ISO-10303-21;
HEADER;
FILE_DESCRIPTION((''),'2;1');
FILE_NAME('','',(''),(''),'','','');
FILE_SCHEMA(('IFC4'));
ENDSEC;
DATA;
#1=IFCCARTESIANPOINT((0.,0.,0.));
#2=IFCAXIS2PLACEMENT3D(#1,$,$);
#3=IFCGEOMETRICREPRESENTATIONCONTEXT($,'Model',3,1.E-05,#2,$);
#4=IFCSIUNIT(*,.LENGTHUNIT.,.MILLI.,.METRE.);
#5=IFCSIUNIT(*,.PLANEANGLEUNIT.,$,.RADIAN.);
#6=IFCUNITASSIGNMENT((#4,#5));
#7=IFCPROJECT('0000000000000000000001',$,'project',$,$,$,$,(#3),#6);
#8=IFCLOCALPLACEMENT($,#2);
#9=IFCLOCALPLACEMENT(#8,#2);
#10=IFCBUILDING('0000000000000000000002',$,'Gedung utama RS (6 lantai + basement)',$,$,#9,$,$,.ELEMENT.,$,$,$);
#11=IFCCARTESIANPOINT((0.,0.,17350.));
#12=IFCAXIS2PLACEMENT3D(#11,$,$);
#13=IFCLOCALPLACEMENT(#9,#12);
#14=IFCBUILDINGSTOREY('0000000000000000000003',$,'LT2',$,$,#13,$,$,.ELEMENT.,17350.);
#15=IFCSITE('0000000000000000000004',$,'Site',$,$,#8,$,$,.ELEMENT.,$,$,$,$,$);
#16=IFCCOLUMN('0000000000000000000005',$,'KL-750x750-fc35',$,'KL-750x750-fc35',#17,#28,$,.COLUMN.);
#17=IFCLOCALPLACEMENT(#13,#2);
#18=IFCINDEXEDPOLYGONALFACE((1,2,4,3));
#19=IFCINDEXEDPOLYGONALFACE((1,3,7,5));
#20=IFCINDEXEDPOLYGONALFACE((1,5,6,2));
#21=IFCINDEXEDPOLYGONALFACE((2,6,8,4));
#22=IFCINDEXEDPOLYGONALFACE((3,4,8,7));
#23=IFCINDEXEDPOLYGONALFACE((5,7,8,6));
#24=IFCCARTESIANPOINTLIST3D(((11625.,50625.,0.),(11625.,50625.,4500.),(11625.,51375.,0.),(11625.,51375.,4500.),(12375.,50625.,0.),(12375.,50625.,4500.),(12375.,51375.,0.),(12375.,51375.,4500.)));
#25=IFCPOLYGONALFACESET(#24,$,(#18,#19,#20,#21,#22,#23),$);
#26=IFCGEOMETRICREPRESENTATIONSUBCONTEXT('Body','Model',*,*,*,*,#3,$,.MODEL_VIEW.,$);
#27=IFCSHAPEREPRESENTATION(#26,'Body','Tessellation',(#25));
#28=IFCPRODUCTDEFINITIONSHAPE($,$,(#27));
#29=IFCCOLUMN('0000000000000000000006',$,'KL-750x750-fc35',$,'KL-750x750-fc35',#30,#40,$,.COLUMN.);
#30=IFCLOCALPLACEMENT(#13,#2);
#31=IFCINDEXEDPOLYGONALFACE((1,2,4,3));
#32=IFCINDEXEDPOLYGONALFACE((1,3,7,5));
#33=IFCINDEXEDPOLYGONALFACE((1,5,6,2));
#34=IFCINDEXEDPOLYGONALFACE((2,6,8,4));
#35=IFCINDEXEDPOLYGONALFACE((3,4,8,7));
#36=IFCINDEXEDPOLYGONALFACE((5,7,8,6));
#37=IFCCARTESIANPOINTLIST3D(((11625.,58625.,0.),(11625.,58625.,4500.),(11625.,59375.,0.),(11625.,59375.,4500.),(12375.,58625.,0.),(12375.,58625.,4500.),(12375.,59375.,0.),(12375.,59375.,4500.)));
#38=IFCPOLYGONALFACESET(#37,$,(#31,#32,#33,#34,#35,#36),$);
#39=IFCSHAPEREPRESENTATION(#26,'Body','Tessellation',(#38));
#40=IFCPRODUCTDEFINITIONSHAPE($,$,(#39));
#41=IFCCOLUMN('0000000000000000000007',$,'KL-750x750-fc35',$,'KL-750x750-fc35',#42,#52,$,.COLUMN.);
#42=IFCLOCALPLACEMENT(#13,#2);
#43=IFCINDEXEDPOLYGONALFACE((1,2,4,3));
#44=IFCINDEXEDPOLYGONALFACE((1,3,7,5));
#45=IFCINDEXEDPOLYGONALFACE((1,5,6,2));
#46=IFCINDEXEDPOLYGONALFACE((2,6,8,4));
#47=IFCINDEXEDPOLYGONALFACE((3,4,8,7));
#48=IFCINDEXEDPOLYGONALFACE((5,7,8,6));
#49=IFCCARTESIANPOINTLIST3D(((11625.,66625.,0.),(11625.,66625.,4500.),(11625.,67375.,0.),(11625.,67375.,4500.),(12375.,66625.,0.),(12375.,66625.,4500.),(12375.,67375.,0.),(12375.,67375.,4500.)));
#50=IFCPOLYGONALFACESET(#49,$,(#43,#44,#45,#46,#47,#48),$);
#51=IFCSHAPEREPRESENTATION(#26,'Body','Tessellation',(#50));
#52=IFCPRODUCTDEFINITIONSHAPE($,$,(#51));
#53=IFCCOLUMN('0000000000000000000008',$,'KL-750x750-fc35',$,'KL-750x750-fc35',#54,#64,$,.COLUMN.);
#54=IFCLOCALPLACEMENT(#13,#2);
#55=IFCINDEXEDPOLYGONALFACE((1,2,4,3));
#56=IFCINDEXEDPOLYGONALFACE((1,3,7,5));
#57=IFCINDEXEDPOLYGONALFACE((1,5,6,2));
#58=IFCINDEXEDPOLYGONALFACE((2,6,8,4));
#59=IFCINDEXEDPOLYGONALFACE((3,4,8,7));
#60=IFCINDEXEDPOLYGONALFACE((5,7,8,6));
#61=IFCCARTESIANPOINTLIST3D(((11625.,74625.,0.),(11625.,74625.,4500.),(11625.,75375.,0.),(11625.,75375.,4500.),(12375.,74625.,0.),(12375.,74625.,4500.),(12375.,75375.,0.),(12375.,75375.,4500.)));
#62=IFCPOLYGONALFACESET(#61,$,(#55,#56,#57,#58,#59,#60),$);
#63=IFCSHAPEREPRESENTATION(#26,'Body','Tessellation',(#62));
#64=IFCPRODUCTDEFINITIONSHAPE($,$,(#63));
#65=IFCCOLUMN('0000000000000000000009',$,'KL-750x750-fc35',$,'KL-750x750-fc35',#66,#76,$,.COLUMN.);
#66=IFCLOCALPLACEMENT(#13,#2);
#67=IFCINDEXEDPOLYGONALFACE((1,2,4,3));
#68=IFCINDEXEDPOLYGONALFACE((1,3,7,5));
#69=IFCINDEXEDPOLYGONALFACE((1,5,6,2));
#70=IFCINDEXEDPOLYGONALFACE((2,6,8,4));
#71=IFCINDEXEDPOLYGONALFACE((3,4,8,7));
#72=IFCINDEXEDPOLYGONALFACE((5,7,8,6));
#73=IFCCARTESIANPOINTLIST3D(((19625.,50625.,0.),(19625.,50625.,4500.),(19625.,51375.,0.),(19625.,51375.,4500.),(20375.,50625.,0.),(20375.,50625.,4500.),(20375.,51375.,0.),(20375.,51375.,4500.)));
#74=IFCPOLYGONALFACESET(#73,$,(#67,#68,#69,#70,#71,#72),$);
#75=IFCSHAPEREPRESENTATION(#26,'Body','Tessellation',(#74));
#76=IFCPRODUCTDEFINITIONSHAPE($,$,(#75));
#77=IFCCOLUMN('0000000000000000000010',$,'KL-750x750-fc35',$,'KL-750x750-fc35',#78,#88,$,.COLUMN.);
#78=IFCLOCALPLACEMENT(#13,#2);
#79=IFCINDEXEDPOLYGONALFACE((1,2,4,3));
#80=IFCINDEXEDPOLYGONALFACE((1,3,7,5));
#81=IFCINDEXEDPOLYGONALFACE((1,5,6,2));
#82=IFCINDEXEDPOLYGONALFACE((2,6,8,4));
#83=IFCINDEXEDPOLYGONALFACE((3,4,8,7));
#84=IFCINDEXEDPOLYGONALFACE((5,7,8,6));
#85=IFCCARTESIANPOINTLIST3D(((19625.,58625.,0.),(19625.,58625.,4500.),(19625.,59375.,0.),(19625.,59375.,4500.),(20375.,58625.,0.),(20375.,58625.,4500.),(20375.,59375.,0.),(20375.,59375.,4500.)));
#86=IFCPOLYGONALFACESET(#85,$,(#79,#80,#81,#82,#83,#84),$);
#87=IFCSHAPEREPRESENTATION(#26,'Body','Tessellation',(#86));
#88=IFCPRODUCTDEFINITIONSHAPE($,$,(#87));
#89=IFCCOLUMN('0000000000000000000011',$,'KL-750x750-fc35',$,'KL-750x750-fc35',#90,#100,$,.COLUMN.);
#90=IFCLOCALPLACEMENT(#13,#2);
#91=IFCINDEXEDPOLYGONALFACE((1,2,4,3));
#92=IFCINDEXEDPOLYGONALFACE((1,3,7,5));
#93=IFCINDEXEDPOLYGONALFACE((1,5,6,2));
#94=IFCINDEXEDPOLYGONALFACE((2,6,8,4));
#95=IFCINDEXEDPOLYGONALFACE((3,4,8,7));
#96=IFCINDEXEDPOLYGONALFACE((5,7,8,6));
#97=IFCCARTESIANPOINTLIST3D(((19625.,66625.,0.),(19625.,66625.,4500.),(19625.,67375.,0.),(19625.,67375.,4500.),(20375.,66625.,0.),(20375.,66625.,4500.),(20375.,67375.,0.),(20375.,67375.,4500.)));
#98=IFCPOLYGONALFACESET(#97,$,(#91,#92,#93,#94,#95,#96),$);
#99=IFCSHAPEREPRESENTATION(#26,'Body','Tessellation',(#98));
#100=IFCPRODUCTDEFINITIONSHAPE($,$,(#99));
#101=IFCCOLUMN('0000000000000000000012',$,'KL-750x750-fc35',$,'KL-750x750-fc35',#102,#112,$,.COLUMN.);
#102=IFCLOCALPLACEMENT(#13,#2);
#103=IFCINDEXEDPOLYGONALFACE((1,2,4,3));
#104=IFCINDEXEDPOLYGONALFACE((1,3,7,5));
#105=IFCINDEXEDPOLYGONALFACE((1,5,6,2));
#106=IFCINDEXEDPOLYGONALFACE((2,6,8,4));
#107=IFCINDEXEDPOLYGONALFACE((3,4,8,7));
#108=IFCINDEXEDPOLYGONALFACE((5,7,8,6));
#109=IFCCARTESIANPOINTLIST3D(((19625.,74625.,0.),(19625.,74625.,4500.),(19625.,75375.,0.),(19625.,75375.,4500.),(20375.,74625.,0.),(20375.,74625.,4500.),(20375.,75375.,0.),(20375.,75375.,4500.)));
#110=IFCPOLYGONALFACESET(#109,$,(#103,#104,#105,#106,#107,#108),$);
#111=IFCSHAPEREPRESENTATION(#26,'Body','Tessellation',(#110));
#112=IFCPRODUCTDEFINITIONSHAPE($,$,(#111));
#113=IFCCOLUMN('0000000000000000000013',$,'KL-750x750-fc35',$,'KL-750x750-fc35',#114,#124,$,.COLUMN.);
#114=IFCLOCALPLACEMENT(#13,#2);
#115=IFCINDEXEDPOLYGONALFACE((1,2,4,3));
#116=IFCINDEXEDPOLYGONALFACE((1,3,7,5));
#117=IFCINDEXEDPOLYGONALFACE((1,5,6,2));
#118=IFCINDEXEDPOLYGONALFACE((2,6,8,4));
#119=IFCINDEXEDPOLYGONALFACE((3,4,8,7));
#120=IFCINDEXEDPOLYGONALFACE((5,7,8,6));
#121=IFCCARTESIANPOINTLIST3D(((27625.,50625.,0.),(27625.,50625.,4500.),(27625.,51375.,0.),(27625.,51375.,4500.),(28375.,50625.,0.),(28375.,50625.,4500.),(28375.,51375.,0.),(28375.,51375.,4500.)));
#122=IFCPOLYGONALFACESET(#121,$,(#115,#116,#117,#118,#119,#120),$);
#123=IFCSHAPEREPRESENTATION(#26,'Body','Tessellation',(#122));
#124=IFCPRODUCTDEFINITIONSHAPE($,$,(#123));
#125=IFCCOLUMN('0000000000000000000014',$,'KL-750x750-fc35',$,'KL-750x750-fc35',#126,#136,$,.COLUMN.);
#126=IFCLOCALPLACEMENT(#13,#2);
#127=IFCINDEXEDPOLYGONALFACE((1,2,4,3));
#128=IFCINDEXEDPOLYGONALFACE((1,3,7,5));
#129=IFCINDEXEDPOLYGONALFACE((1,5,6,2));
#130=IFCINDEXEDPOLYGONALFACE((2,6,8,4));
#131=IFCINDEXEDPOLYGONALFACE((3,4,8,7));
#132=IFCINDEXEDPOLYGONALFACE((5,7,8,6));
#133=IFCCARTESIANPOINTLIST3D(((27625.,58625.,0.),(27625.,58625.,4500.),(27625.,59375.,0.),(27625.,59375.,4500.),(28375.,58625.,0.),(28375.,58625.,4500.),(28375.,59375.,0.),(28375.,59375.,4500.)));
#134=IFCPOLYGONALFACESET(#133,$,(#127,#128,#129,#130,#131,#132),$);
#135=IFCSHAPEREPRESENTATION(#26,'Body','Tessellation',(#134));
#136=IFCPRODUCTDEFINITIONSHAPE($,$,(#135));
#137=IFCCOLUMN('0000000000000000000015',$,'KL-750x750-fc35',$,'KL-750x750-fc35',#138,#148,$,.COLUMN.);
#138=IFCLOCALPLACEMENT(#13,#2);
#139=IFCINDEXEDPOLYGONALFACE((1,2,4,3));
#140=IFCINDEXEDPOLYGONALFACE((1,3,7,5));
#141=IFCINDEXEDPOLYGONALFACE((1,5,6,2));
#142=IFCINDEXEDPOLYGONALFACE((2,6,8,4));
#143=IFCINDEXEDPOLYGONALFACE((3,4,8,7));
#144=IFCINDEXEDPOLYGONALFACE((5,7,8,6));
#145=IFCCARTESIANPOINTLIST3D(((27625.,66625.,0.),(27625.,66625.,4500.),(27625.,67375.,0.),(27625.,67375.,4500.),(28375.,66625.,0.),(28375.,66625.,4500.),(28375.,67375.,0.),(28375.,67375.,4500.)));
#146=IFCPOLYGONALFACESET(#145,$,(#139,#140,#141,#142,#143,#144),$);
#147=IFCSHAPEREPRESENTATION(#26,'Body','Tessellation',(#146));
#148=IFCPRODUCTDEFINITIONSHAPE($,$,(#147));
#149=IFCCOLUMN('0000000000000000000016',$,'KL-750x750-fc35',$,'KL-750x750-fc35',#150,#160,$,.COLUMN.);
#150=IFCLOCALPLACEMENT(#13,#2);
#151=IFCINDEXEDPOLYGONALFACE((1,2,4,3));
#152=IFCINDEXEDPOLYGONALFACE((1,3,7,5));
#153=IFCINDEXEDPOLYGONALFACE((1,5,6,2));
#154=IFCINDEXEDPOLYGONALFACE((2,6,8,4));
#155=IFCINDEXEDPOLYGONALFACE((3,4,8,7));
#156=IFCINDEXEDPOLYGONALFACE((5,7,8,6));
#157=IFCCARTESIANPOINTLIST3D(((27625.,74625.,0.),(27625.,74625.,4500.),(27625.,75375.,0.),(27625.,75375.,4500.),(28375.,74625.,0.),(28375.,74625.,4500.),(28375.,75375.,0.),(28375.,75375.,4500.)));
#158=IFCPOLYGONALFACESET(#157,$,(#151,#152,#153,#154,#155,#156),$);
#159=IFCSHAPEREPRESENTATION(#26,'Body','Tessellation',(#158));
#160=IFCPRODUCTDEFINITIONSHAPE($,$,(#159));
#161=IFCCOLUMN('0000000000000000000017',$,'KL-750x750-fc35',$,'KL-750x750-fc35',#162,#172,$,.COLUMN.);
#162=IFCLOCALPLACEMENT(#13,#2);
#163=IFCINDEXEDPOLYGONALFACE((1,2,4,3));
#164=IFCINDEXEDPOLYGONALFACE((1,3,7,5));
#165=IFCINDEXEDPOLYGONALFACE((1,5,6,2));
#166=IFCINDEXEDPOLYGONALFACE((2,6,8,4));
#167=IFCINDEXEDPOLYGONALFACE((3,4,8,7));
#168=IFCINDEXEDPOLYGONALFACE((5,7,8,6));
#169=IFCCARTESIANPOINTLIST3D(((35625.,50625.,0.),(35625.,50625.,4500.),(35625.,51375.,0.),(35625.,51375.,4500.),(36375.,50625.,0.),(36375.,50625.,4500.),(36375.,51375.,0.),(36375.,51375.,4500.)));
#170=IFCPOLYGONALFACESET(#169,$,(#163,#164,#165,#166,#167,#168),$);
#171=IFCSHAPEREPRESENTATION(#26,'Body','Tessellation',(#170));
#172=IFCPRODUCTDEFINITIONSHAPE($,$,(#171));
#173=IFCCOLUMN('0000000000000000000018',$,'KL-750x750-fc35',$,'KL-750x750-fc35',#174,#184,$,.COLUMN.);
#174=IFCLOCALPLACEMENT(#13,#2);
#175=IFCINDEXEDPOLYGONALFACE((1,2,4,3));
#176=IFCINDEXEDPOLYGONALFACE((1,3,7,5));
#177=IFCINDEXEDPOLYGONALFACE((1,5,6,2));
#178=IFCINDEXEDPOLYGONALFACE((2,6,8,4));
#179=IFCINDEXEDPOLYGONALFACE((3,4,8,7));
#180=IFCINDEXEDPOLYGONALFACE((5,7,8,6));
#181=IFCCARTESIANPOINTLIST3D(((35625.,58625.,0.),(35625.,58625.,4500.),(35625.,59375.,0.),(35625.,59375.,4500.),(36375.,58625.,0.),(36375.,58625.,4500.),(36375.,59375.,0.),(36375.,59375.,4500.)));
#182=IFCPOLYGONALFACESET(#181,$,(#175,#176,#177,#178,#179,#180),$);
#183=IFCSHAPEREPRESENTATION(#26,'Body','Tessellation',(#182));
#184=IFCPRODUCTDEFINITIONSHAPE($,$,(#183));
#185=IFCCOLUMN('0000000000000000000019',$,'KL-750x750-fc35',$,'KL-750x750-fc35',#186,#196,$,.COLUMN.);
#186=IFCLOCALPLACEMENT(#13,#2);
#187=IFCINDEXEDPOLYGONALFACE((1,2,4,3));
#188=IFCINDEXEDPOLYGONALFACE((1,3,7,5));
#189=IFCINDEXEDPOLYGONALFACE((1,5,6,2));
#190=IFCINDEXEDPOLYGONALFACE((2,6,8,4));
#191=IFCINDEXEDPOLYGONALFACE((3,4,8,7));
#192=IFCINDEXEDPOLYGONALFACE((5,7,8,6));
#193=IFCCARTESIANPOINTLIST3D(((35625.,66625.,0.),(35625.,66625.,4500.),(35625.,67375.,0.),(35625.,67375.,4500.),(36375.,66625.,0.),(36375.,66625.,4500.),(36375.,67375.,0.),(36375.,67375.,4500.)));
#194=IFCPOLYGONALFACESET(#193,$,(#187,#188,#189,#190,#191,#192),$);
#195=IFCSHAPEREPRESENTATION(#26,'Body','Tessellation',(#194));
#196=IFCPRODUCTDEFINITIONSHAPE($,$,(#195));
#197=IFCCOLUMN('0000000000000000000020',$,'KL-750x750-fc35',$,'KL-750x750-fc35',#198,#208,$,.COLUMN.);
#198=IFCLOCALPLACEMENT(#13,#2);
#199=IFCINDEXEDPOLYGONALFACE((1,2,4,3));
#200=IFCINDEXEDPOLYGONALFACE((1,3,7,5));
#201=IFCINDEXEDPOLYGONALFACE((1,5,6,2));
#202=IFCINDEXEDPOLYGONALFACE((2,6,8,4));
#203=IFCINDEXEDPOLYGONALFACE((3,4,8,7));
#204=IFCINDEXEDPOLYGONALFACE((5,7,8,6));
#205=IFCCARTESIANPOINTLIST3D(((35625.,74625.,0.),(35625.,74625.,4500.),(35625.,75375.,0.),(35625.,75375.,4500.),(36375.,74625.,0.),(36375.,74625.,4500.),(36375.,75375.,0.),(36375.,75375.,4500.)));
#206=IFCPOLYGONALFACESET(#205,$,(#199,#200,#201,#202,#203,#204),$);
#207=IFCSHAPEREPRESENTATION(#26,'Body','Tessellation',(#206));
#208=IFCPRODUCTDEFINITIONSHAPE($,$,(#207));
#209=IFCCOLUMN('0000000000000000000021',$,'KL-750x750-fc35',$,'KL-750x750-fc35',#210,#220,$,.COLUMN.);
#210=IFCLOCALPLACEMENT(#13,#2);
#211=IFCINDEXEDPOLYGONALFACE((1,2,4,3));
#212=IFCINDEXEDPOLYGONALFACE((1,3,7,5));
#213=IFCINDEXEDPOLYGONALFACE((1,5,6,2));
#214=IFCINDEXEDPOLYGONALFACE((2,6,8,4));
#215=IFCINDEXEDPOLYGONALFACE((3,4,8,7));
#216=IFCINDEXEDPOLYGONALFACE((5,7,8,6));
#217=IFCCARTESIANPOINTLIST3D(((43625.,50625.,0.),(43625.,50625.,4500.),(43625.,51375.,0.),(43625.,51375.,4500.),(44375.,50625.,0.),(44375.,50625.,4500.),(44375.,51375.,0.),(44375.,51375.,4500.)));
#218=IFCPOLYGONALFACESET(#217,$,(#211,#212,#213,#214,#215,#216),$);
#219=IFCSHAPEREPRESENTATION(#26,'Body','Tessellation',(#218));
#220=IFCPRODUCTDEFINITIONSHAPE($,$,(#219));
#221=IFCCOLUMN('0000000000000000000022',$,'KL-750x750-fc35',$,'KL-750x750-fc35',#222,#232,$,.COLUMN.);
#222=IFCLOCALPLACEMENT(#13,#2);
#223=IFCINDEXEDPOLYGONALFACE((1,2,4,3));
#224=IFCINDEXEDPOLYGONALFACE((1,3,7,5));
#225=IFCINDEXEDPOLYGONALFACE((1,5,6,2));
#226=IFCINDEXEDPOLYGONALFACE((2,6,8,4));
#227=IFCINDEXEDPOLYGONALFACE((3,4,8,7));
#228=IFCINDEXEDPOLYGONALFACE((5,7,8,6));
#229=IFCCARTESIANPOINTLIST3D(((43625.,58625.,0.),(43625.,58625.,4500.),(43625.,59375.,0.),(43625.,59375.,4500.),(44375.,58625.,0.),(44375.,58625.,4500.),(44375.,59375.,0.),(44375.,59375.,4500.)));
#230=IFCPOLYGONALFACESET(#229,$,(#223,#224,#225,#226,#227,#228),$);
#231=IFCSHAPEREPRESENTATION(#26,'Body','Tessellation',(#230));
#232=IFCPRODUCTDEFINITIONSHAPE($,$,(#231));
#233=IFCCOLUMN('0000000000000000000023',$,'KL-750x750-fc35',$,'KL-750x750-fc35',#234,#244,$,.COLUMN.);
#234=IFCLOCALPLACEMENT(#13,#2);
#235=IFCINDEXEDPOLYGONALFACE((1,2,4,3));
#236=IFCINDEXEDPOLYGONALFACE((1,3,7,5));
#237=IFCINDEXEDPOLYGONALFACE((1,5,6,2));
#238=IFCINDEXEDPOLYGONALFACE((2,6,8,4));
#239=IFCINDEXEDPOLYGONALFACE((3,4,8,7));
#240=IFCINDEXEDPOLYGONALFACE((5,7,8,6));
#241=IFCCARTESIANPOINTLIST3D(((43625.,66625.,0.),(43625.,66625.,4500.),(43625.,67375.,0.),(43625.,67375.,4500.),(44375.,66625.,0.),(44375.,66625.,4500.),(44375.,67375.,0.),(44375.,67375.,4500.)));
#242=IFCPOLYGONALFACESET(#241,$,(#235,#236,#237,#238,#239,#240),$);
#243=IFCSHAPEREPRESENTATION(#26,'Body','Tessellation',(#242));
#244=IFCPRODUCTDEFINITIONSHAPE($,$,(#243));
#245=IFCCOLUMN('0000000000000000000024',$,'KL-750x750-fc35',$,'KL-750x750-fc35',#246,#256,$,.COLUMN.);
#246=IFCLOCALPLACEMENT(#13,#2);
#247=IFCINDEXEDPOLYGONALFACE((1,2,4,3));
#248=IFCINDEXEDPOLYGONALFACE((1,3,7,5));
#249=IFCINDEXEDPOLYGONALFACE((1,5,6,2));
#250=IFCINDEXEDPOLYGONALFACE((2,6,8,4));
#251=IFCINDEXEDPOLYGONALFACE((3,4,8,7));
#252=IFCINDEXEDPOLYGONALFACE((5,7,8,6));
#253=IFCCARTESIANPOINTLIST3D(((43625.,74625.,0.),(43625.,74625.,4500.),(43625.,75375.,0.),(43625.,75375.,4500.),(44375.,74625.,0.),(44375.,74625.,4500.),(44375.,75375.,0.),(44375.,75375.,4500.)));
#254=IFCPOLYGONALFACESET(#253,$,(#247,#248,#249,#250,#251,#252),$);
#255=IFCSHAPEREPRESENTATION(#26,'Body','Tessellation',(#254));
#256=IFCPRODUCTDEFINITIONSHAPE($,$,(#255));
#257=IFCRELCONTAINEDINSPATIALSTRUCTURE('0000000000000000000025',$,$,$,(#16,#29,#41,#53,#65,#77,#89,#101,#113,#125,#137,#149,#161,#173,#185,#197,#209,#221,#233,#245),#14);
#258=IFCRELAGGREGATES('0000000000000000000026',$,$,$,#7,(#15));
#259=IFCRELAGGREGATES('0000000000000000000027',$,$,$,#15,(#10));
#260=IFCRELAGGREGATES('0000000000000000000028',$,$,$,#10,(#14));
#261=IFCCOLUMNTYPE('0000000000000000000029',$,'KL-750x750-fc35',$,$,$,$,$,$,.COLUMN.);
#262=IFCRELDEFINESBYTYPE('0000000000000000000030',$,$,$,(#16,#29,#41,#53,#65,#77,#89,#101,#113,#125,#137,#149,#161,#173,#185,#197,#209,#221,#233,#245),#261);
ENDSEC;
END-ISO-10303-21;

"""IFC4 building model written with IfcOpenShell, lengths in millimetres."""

from ifc_helpers import new_model, si_unit, frame, origin, origin_2d, place, context, subcontext, project, spatial, rectangle, extrude, material_profile, profile_set, profile_usage, type_object, element, save


model = new_model("IFC4")

# Units and contexts
model_context = context("Model", 3, precision=1e-05, world=origin())
body_context = subcontext(model_context, "Body", "Model", "MODEL_VIEW")
ifc_project = project(units=[si_unit("LENGTHUNIT", "METRE", prefix="MILLI"), si_unit("PLANEANGLEUNIT", "RADIAN")], contexts=[model_context])

# Site, building, storey
site_placement = place(None, origin())
site = spatial("IfcSite", under=ifc_project, at=site_placement, Name="Site", CompositionType="ELEMENT")
building_placement = place(site_placement, origin())
building = spatial("IfcBuilding", under=site, at=building_placement, Name="Gedung utama RS (6 lantai + basement)", CompositionType="ELEMENT")
storey_placement = place(building_placement, frame((0.0, 0.0, 17350.0)))
storey = spatial("IfcBuildingStorey", under=building, at=storey_placement, Name="LT2", CompositionType="ELEMENT", Elevation=17350.0)

# Columns
ifc_material_profile_1 = material_profile(None, rectangle(XDim=750.0, YDim=750.0, at=origin_2d()), Name="KL-750x750-fc35")
ifc_profile_set_1 = profile_set([ifc_material_profile_1], Name="KL-750x750-fc35")
ifc_profile_usage_1 = profile_usage(ifc_profile_set_1, cardinal=5)
column_type = type_object("IfcColumnType", Name="KL-750x750-fc35", PredefinedType="COLUMN", material=ifc_profile_set_1)
for number, where, z_axis, x_axis, name in (
    (1, (12000.0, 51000.0, 0.0), (0.0, 0.0, 1.0), (1.0, 0.0, 0.0), "KL-750x750-fc35"),
    (2, (12000.0, 59000.0, 0.0), (0.0, 0.0, 1.0), (1.0, 0.0, 0.0), "KL-750x750-fc35"),
    (3, (12000.0, 67000.0, 0.0), (0.0, 0.0, 1.0), (1.0, 0.0, 0.0), "KL-750x750-fc35"),
    (4, (12000.0, 75000.0, 0.0), (0.0, 0.0, 1.0), (1.0, 0.0, 0.0), "KL-750x750-fc35"),
    (5, (20000.0, 51000.0, 0.0), (0.0, 0.0, 1.0), (1.0, 0.0, 0.0), "KL-750x750-fc35"),
    (6, (20000.0, 59000.0, 0.0), (0.0, 0.0, 1.0), (1.0, 0.0, 0.0), "KL-750x750-fc35"),
    (7, (20000.0, 67000.0, 0.0), (0.0, 0.0, 1.0), (1.0, 0.0, 0.0), "KL-750x750-fc35"),
    (8, (20000.0, 75000.0, 0.0), (0.0, 0.0, 1.0), (1.0, 0.0, 0.0), "KL-750x750-fc35"),
    (9, (28000.0, 51000.0, 0.0), (0.0, 0.0, 1.0), (1.0, 0.0, 0.0), "KL-750x750-fc35"),
    (10, (28000.0, 59000.0, 0.0), (0.0, 0.0, 1.0), (1.0, 0.0, 0.0), "KL-750x750-fc35"),
    (11, (28000.0, 67000.0, 0.0), (0.0, 0.0, 1.0), (1.0, 0.0, 0.0), "KL-750x750-fc35"),
    (12, (28000.0, 75000.0, 0.0), (0.0, 0.0, 1.0), (1.0, 0.0, 0.0), "KL-750x750-fc35"),
    (13, (36000.0, 51000.0, 0.0), (0.0, 0.0, 1.0), (1.0, 0.0, 0.0), "KL-750x750-fc35"),
    (14, (36000.0, 59000.0, 0.0), (0.0, 0.0, 1.0), (1.0, 0.0, 0.0), "KL-750x750-fc35"),
    (15, (36000.0, 67000.0, 0.0), (0.0, 0.0, 1.0), (1.0, 0.0, 0.0), "KL-750x750-fc35"),
    (16, (36000.0, 75000.0, 0.0), (0.0, 0.0, 1.0), (1.0, 0.0, 0.0), "KL-750x750-fc35"),
    (17, (44000.0, 51000.0, 0.0), (0.0, 0.0, 1.0), (1.0, 0.0, 0.0), "KL-750x750-fc35"),
    (18, (44000.0, 59000.0, 0.0), (0.0, 0.0, 1.0), (1.0, 0.0, 0.0), "KL-750x750-fc35"),
    (19, (44000.0, 67000.0, 0.0), (0.0, 0.0, 1.0), (1.0, 0.0, 0.0), "KL-750x750-fc35"),
    (20, (44000.0, 75000.0, 0.0), (0.0, 0.0, 1.0), (1.0, 0.0, 0.0), "KL-750x750-fc35"),
):
    element("IfcColumn", number, at=place(storey_placement, frame(where, z_axis=z_axis, x_axis=x_axis)), inside=storey, type_object=column_type, material=ifc_profile_usage_1, Name=name, ObjectType="KL-750x750-fc35", PredefinedType="COLUMN", context=body_context, shape_type="SweptSolid", body=[
        extrude(rectangle(XDim=750.0, YDim=750.0, at=origin_2d()), origin(), (0.0, 0.0, 1.0), 4500.0),
    ])

save(model, "model.ifc")
